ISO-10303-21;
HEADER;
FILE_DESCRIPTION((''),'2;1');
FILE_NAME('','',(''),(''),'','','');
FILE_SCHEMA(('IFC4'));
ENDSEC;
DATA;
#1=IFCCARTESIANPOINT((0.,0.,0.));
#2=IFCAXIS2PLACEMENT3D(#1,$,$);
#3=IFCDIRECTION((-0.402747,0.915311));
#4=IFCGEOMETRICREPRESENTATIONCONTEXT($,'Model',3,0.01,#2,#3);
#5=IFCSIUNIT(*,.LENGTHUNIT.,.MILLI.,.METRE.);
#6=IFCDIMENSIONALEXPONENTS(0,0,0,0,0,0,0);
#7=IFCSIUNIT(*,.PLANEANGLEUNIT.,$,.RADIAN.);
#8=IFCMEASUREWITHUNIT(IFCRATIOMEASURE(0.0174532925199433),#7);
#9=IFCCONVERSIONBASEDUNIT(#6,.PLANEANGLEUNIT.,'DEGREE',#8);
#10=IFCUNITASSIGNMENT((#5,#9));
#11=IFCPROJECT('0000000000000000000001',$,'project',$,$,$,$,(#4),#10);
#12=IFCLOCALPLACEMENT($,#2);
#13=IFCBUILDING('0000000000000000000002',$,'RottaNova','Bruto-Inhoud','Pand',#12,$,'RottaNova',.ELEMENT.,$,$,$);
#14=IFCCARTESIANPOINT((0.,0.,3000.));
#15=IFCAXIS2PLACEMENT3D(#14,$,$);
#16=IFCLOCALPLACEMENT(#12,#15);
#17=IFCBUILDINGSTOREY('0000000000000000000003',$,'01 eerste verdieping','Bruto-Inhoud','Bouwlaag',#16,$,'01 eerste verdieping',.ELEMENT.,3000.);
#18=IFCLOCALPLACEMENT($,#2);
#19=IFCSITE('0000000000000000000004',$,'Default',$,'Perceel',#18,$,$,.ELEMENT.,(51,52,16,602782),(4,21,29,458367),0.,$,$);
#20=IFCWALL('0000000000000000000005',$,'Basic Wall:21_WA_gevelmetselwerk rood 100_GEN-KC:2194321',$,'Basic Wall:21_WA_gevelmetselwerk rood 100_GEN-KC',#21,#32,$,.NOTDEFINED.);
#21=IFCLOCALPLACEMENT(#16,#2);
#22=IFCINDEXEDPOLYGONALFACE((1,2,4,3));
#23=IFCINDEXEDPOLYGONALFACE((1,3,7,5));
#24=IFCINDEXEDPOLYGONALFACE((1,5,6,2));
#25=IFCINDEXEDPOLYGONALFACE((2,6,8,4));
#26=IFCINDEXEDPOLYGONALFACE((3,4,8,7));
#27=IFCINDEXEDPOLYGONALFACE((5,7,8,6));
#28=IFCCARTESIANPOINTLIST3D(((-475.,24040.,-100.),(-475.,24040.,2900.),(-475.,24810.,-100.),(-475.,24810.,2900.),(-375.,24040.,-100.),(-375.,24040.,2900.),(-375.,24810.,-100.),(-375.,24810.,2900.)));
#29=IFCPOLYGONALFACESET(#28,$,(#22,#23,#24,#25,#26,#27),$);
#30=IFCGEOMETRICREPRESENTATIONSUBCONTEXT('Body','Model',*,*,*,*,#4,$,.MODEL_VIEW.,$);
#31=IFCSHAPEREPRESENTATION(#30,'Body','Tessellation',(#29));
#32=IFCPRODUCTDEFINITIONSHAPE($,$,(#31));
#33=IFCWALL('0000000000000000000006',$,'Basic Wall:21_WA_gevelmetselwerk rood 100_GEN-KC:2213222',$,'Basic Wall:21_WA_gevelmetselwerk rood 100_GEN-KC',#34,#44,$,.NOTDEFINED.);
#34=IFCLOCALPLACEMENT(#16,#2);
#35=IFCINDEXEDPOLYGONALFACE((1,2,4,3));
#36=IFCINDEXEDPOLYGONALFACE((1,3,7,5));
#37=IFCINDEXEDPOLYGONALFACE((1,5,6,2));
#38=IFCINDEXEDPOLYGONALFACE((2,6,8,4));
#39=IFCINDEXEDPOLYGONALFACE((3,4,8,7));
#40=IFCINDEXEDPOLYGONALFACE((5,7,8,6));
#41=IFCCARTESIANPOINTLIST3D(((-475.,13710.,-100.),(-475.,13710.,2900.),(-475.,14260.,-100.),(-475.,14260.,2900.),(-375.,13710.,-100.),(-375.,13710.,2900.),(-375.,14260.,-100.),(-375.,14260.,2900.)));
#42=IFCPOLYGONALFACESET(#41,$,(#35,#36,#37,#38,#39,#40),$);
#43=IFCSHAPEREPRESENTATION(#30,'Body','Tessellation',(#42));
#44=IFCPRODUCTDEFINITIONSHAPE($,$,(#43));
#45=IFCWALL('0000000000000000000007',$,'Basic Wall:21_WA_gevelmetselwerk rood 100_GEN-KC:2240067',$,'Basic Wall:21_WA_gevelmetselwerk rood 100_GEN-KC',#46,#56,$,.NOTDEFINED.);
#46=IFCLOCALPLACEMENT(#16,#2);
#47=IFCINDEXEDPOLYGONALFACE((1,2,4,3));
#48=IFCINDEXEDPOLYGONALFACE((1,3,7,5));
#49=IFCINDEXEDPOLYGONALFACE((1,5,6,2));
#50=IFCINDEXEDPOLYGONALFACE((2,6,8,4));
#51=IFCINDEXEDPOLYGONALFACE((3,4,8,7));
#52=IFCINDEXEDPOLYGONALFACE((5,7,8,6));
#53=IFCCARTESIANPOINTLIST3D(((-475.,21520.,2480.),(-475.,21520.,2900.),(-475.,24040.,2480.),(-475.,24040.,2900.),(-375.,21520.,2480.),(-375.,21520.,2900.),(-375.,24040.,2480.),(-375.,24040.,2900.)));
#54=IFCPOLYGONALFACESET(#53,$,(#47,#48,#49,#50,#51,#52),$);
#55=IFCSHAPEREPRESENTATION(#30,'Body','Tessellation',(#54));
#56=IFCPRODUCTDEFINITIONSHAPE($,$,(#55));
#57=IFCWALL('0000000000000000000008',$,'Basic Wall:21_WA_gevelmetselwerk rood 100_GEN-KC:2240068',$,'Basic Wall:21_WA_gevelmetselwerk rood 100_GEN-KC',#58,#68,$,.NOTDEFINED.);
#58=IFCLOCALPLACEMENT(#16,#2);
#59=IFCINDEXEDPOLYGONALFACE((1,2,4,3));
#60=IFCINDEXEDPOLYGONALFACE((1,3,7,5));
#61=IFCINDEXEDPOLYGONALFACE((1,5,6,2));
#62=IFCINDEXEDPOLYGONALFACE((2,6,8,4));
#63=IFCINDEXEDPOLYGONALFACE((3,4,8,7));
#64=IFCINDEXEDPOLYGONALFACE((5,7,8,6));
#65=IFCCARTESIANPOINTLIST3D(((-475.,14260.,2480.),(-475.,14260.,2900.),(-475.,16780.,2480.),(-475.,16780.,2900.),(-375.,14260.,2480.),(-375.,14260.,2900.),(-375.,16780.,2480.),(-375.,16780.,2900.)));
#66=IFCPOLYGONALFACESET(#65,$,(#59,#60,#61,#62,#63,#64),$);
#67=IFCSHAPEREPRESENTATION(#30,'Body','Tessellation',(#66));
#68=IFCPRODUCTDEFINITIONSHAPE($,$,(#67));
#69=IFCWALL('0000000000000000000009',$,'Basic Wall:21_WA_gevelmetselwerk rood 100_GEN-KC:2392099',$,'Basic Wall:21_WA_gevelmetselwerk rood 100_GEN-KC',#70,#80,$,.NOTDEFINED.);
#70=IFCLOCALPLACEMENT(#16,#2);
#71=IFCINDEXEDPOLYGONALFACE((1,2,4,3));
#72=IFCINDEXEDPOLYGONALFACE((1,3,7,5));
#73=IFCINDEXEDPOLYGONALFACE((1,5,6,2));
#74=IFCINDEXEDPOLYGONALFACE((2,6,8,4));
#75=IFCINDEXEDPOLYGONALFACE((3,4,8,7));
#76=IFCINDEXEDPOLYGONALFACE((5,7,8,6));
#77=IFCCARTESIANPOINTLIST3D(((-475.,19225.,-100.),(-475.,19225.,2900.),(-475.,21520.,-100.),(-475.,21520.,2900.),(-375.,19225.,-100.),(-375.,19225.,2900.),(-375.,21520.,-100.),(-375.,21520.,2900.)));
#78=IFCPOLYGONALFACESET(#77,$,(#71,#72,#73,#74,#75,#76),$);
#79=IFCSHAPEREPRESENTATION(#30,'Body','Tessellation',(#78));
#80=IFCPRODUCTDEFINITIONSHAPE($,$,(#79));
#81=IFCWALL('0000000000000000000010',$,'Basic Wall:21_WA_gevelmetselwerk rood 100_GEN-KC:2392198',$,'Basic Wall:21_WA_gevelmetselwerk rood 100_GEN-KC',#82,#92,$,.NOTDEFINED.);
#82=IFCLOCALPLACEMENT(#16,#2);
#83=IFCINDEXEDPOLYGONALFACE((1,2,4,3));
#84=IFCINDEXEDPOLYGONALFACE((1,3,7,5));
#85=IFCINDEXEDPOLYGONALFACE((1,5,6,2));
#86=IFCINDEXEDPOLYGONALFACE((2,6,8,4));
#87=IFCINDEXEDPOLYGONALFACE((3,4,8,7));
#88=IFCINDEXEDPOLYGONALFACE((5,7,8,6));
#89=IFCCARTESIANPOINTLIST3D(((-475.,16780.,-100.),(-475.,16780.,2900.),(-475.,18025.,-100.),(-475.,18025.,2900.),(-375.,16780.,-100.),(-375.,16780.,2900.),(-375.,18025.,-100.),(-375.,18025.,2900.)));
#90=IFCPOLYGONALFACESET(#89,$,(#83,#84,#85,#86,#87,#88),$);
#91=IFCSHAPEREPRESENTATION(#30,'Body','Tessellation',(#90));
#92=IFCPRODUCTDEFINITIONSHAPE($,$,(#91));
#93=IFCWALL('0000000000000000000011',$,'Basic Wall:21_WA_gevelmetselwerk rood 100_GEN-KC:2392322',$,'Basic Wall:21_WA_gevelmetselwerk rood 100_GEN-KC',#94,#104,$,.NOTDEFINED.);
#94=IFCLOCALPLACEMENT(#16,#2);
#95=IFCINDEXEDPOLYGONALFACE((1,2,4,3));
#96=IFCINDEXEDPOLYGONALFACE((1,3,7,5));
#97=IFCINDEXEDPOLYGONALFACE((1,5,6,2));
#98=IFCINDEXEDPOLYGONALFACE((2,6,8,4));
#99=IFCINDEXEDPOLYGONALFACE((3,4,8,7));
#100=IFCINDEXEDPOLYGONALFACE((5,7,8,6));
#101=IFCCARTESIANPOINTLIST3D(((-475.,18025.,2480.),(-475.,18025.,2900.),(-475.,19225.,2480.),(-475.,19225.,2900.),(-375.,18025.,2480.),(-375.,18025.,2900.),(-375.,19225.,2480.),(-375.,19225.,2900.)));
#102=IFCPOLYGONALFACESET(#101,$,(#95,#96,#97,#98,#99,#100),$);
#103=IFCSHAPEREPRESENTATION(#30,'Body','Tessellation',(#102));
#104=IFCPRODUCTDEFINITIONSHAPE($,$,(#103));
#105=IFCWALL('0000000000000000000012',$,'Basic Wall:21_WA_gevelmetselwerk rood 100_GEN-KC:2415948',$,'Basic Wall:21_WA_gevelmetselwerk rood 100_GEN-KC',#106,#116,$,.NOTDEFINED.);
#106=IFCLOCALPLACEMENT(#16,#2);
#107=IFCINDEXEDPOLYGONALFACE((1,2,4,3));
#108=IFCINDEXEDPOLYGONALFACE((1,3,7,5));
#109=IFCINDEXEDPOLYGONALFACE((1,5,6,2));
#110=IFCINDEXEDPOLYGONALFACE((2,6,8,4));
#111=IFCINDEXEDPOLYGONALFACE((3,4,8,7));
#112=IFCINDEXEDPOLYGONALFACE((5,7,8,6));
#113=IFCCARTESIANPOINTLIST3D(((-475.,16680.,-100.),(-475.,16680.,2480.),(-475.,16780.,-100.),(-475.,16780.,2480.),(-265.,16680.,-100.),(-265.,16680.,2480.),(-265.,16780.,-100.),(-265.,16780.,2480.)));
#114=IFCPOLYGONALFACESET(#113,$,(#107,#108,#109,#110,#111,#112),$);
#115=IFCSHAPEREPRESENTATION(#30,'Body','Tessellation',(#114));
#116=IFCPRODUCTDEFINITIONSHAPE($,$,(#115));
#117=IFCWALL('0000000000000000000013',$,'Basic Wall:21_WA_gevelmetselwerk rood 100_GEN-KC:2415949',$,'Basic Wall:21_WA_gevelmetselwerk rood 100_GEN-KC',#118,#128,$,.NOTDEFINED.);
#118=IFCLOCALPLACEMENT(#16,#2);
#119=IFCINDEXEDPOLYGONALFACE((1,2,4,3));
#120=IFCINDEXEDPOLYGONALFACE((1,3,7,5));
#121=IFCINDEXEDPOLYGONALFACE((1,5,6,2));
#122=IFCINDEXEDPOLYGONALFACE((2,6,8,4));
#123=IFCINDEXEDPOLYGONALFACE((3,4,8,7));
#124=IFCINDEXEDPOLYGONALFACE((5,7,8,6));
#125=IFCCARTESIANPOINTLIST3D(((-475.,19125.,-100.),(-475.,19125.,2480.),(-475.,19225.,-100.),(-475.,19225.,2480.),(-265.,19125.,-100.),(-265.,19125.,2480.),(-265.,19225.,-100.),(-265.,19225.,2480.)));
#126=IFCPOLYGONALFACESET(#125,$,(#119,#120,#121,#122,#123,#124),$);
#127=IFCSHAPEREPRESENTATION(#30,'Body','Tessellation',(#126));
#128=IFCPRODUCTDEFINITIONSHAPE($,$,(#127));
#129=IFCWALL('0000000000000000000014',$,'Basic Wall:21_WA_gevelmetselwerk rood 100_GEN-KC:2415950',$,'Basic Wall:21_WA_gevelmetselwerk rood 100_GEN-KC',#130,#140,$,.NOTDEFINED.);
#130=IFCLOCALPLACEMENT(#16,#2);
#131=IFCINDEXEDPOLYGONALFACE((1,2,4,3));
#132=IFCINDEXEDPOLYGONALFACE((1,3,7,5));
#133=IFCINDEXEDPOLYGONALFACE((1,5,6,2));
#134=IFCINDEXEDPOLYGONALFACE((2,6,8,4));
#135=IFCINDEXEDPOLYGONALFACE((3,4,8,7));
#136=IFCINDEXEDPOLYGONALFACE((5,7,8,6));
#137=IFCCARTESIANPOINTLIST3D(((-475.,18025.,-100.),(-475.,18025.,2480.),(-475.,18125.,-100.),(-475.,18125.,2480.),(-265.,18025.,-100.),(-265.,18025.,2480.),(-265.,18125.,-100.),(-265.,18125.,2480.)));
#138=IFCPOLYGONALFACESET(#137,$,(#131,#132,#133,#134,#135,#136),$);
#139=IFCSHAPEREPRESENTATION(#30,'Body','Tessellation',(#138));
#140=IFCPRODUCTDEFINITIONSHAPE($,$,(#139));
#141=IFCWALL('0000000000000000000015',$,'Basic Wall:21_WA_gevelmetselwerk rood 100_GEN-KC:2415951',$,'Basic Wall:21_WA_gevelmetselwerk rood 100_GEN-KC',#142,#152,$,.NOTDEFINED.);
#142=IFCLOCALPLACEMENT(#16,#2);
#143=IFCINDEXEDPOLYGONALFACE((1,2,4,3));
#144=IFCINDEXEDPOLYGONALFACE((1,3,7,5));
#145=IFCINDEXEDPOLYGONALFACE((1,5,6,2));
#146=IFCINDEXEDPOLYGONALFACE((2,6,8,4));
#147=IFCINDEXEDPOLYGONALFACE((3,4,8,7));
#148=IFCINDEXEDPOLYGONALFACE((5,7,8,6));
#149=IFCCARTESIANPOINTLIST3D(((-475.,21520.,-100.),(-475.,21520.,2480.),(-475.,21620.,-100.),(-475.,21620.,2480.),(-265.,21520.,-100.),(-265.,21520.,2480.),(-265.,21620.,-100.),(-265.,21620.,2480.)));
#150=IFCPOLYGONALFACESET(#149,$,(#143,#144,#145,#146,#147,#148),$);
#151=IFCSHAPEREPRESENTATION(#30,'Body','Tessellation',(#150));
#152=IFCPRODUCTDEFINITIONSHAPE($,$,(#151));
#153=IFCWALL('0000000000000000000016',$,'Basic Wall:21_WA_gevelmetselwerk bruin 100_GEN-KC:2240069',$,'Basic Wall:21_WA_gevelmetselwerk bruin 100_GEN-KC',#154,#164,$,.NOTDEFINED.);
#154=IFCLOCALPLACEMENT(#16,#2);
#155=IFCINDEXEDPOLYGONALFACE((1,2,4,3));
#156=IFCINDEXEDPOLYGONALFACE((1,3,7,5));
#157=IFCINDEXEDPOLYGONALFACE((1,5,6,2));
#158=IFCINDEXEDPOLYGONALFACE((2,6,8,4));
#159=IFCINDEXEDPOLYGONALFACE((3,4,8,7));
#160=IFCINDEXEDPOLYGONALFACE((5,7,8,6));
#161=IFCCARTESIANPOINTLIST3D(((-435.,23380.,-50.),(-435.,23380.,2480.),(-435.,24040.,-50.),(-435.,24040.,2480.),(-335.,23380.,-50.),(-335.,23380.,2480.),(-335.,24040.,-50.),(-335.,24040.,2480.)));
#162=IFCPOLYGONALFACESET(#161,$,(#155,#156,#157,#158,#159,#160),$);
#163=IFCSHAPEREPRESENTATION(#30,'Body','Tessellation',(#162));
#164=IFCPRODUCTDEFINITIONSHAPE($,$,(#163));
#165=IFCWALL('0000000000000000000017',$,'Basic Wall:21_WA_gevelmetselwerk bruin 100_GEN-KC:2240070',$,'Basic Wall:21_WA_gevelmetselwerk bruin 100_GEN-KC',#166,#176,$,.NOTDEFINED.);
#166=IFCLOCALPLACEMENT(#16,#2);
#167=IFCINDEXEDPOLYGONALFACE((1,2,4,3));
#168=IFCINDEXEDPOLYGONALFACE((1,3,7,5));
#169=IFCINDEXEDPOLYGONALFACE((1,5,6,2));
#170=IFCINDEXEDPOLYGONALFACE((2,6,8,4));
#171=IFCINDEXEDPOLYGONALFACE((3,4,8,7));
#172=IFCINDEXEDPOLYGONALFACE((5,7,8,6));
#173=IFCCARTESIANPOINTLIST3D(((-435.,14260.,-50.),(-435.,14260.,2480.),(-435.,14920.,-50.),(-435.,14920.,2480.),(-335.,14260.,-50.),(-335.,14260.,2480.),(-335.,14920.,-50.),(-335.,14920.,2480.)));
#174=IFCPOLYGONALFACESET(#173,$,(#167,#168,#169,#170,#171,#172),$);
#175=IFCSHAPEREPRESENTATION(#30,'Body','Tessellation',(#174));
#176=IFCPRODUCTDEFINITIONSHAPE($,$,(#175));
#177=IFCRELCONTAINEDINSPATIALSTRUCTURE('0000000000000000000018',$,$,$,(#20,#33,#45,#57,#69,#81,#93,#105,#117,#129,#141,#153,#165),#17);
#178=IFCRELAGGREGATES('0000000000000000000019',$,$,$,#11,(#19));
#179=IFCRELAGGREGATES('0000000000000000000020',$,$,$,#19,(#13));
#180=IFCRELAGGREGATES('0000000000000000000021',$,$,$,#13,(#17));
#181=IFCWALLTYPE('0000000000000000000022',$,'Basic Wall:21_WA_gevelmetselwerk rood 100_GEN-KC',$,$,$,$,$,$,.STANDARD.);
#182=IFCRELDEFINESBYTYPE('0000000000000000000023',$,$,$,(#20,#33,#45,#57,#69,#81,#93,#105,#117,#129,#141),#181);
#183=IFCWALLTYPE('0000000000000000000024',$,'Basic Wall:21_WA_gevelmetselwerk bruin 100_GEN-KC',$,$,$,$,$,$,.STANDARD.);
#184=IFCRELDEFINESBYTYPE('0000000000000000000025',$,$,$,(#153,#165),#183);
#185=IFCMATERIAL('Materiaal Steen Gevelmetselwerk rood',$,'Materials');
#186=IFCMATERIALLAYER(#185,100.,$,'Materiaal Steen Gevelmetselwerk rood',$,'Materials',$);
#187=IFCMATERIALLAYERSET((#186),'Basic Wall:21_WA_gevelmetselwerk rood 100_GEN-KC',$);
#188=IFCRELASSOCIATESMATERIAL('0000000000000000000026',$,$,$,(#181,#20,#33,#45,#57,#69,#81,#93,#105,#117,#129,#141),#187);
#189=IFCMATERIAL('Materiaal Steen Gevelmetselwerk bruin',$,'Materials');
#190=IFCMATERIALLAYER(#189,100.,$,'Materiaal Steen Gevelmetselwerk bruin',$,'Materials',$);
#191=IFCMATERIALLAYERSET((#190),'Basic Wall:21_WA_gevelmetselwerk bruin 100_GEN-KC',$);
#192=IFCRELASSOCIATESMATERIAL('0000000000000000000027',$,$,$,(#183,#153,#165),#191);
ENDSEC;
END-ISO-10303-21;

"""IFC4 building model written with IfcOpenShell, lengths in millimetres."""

from ifc_helpers import new_model, entity, si_unit, converted_unit, direction, frame, frame_2d, origin, place, context, subcontext, project, spatial, rectangle, extrude, material, layer, layer_set, type_object, element, save


model = new_model("IFC4")

# Units and contexts
model_context = context("Model", 3, precision=0.01, world=origin(), true_north=direction((-0.402747, 0.915311)))
body_context = subcontext(model_context, "Body", "Model", "MODEL_VIEW")
ifc_project = project(units=[si_unit("LENGTHUNIT", "METRE", prefix="MILLI"), converted_unit("PLANEANGLEUNIT", "DEGREE", entity("IfcRatioMeasure", 0.0174532925199433), si_unit("PLANEANGLEUNIT", "RADIAN"), dimensions=[0, 0, 0, 0, 0, 0, 0])], contexts=[model_context])

# Site, building, storey
site_placement = place(None, origin())
site = spatial("IfcSite", under=ifc_project, at=site_placement, Name="Default", ObjectType="Perceel", CompositionType="ELEMENT", RefLatitude=(51, 52, 16, 602782), RefLongitude=(4, 21, 29, 458367), RefElevation=0.0)
building_placement = place(None, origin())
building = spatial("IfcBuilding", under=site, at=building_placement, Name="RottaNova", Description="Bruto-Inhoud", ObjectType="Pand", LongName="RottaNova", CompositionType="ELEMENT")
storey_placement = place(building_placement, frame((0.0, 0.0, 3000.0)))
storey = spatial("IfcBuildingStorey", under=building, at=storey_placement, Name="01 eerste verdieping", Description="Bruto-Inhoud", ObjectType="Bouwlaag", LongName="01 eerste verdieping", CompositionType="ELEMENT", Elevation=3000.0)

# Walls
ifc_material_1 = material(Name="Materiaal Steen Gevelmetselwerk rood", Category="Materials")
ifc_layer_1 = layer(ifc_material_1, 100.0, Name="Materiaal Steen Gevelmetselwerk rood", Category="Materials")
ifc_layer_set_1 = layer_set([ifc_layer_1], Name="Basic Wall:21_WA_gevelmetselwerk rood 100_GEN-KC")
wall_type_1 = type_object("IfcWallType", Name="Basic Wall:21_WA_gevelmetselwerk rood 100_GEN-KC", PredefinedType="STANDARD", material=ifc_layer_set_1)
wall_1_placement = place(storey_placement, frame((-425.0, 24810.0, -100.0), z_axis=(0.0, 0.0, 1.0), x_axis=(0.0, -1.0, 0.0)))
element("IfcWall", 1, at=wall_1_placement, inside=storey, type_object=wall_type_1, material=ifc_layer_set_1, Name="Basic Wall:21_WA_gevelmetselwerk rood 100_GEN-KC:2194321", ObjectType="Basic Wall:21_WA_gevelmetselwerk rood 100_GEN-KC", PredefinedType="NOTDEFINED", context=body_context, shape_type="SweptSolid", body=[
    extrude(rectangle(XDim=770.0, YDim=100.0, at=frame_2d((385.0, 0.0), x_axis=(-1.0, 0.0))), origin(), (0.0, 0.0, 1.0), 3000.0),
])
wall_2_placement = place(storey_placement, frame((-425.0, 13710.0, -100.0), z_axis=(0.0, 0.0, 1.0), x_axis=(0.0, 1.0, 0.0)))
element("IfcWall", 2, at=wall_2_placement, inside=storey, type_object=wall_type_1, material=ifc_layer_set_1, Name="Basic Wall:21_WA_gevelmetselwerk rood 100_GEN-KC:2213222", ObjectType="Basic Wall:21_WA_gevelmetselwerk rood 100_GEN-KC", PredefinedType="NOTDEFINED", context=body_context, shape_type="SweptSolid", body=[
    extrude(rectangle(XDim=550.0, YDim=100.0, at=frame_2d((275.0, 0.0), x_axis=(-1.0, 0.0))), origin(), (0.0, 0.0, 1.0), 3000.0),
])
wall_3_placement = place(storey_placement, frame((-425.0, 24040.0, 2480.0), z_axis=(0.0, 0.0, 1.0), x_axis=(0.0, -1.0, 0.0)))
element("IfcWall", 3, at=wall_3_placement, inside=storey, type_object=wall_type_1, material=ifc_layer_set_1, Name="Basic Wall:21_WA_gevelmetselwerk rood 100_GEN-KC:2240067", ObjectType="Basic Wall:21_WA_gevelmetselwerk rood 100_GEN-KC", PredefinedType="NOTDEFINED", context=body_context, shape_type="SweptSolid", body=[
    extrude(rectangle(XDim=2520.0, YDim=100.0, at=frame_2d((1260.0, 0.0), x_axis=(-1.0, 0.0))), origin(), (0.0, 0.0, 1.0), 420.0),
])
wall_4_placement = place(storey_placement, frame((-425.0, 14260.0, 2480.0), z_axis=(0.0, 0.0, 1.0), x_axis=(0.0, 1.0, 0.0)))
element("IfcWall", 4, at=wall_4_placement, inside=storey, type_object=wall_type_1, material=ifc_layer_set_1, Name="Basic Wall:21_WA_gevelmetselwerk rood 100_GEN-KC:2240068", ObjectType="Basic Wall:21_WA_gevelmetselwerk rood 100_GEN-KC", PredefinedType="NOTDEFINED", context=body_context, shape_type="SweptSolid", body=[
    extrude(rectangle(XDim=2520.0, YDim=100.0, at=frame_2d((1260.0, 0.0), x_axis=(-1.0, 0.0))), origin(), (0.0, 0.0, 1.0), 420.0),
])
wall_5_placement = place(storey_placement, frame((-425.0, 21520.0, -100.0), z_axis=(0.0, 0.0, 1.0), x_axis=(0.0, -1.0, 0.0)))
element("IfcWall", 5, at=wall_5_placement, inside=storey, type_object=wall_type_1, material=ifc_layer_set_1, Name="Basic Wall:21_WA_gevelmetselwerk rood 100_GEN-KC:2392099", ObjectType="Basic Wall:21_WA_gevelmetselwerk rood 100_GEN-KC", PredefinedType="NOTDEFINED", context=body_context, shape_type="SweptSolid", body=[
    extrude(rectangle(XDim=2295.0, YDim=100.0, at=frame_2d((1147.5, 0.0), x_axis=(-1.0, 0.0))), origin(), (0.0, 0.0, 1.0), 3000.0),
])
wall_6_placement = place(storey_placement, frame((-425.0, 16780.0, -100.0), z_axis=(0.0, 0.0, 1.0), x_axis=(0.0, 1.0, 0.0)))
element("IfcWall", 6, at=wall_6_placement, inside=storey, type_object=wall_type_1, material=ifc_layer_set_1, Name="Basic Wall:21_WA_gevelmetselwerk rood 100_GEN-KC:2392198", ObjectType="Basic Wall:21_WA_gevelmetselwerk rood 100_GEN-KC", PredefinedType="NOTDEFINED", context=body_context, shape_type="SweptSolid", body=[
    extrude(rectangle(XDim=1245.0, YDim=100.0, at=frame_2d((622.5, 0.0), x_axis=(-1.0, 0.0))), origin(), (0.0, 0.0, 1.0), 3000.0),
])
wall_7_placement = place(storey_placement, frame((-425.0, 19225.0, 2480.0), z_axis=(0.0, 0.0, 1.0), x_axis=(0.0, -1.0, 0.0)))
element("IfcWall", 7, at=wall_7_placement, inside=storey, type_object=wall_type_1, material=ifc_layer_set_1, Name="Basic Wall:21_WA_gevelmetselwerk rood 100_GEN-KC:2392322", ObjectType="Basic Wall:21_WA_gevelmetselwerk rood 100_GEN-KC", PredefinedType="NOTDEFINED", context=body_context, shape_type="SweptSolid", body=[
    extrude(rectangle(XDim=1200.0, YDim=100.0, at=frame_2d((600.0, 0.0), x_axis=(-1.0, 0.0))), origin(), (0.0, 0.0, 1.0), 420.0),
])
wall_8_placement = place(storey_placement, frame((-475.0, 16730.0, -100.0)))
element("IfcWall", 8, at=wall_8_placement, inside=storey, type_object=wall_type_1, material=ifc_layer_set_1, Name="Basic Wall:21_WA_gevelmetselwerk rood 100_GEN-KC:2415948", ObjectType="Basic Wall:21_WA_gevelmetselwerk rood 100_GEN-KC", PredefinedType="NOTDEFINED", context=body_context, shape_type="SweptSolid", body=[
    extrude(rectangle(XDim=210.0, YDim=100.0, at=frame_2d((105.0, 0.0), x_axis=(-1.0, 0.0))), origin(), (0.0, 0.0, 1.0), 2580.0),
])
wall_9_placement = place(storey_placement, frame((-475.0, 19175.0, -100.0)))
element("IfcWall", 9, at=wall_9_placement, inside=storey, type_object=wall_type_1, material=ifc_layer_set_1, Name="Basic Wall:21_WA_gevelmetselwerk rood 100_GEN-KC:2415949", ObjectType="Basic Wall:21_WA_gevelmetselwerk rood 100_GEN-KC", PredefinedType="NOTDEFINED", context=body_context, shape_type="SweptSolid", body=[
    extrude(rectangle(XDim=210.0, YDim=100.0, at=frame_2d((105.0, 0.0), x_axis=(-1.0, 0.0))), origin(), (0.0, 0.0, 1.0), 2580.0),
])
wall_10_placement = place(storey_placement, frame((-475.0, 18075.0, -100.0)))
element("IfcWall", 10, at=wall_10_placement, inside=storey, type_object=wall_type_1, material=ifc_layer_set_1, Name="Basic Wall:21_WA_gevelmetselwerk rood 100_GEN-KC:2415950", ObjectType="Basic Wall:21_WA_gevelmetselwerk rood 100_GEN-KC", PredefinedType="NOTDEFINED", context=body_context, shape_type="SweptSolid", body=[
    extrude(rectangle(XDim=210.0, YDim=100.0, at=frame_2d((105.0, 0.0), x_axis=(-1.0, 0.0))), origin(), (0.0, 0.0, 1.0), 2580.0),
])
wall_11_placement = place(storey_placement, frame((-475.0, 21570.0, -100.0)))
element("IfcWall", 11, at=wall_11_placement, inside=storey, type_object=wall_type_1, material=ifc_layer_set_1, Name="Basic Wall:21_WA_gevelmetselwerk rood 100_GEN-KC:2415951", ObjectType="Basic Wall:21_WA_gevelmetselwerk rood 100_GEN-KC", PredefinedType="NOTDEFINED", context=body_context, shape_type="SweptSolid", body=[
    extrude(rectangle(XDim=210.0, YDim=100.0, at=frame_2d((105.0, 0.0), x_axis=(-1.0, 0.0))), origin(), (0.0, 0.0, 1.0), 2580.0),
])
ifc_material_2 = material(Name="Materiaal Steen Gevelmetselwerk bruin", Category="Materials")
ifc_layer_2 = layer(ifc_material_2, 100.0, Name="Materiaal Steen Gevelmetselwerk bruin", Category="Materials")
ifc_layer_set_2 = layer_set([ifc_layer_2], Name="Basic Wall:21_WA_gevelmetselwerk bruin 100_GEN-KC")
wall_type_2 = type_object("IfcWallType", Name="Basic Wall:21_WA_gevelmetselwerk bruin 100_GEN-KC", PredefinedType="STANDARD", material=ifc_layer_set_2)
wall_12_placement = place(storey_placement, frame((-385.0, 24040.0, -50.0), z_axis=(0.0, 0.0, 1.0), x_axis=(0.0, -1.0, 0.0)))
element("IfcWall", 12, at=wall_12_placement, inside=storey, type_object=wall_type_2, material=ifc_layer_set_2, Name="Basic Wall:21_WA_gevelmetselwerk bruin 100_GEN-KC:2240069", ObjectType="Basic Wall:21_WA_gevelmetselwerk bruin 100_GEN-KC", PredefinedType="NOTDEFINED", context=body_context, shape_type="SweptSolid", body=[
    extrude(rectangle(XDim=660.0, YDim=100.0, at=frame_2d((330.0, 0.0), x_axis=(-1.0, 0.0))), origin(), (0.0, 0.0, 1.0), 2530.0),
])
wall_13_placement = place(storey_placement, frame((-385.0, 14260.0, -50.0), z_axis=(0.0, 0.0, 1.0), x_axis=(0.0, 1.0, 0.0)))
element("IfcWall", 13, at=wall_13_placement, inside=storey, type_object=wall_type_2, material=ifc_layer_set_2, Name="Basic Wall:21_WA_gevelmetselwerk bruin 100_GEN-KC:2240070", ObjectType="Basic Wall:21_WA_gevelmetselwerk bruin 100_GEN-KC", PredefinedType="NOTDEFINED", context=body_context, shape_type="SweptSolid", body=[
    extrude(rectangle(XDim=660.0, YDim=100.0, at=frame_2d((330.0, 0.0), x_axis=(-1.0, 0.0))), origin(), (0.0, 0.0, 1.0), 2530.0),
])

save(model, "model.ifc")
